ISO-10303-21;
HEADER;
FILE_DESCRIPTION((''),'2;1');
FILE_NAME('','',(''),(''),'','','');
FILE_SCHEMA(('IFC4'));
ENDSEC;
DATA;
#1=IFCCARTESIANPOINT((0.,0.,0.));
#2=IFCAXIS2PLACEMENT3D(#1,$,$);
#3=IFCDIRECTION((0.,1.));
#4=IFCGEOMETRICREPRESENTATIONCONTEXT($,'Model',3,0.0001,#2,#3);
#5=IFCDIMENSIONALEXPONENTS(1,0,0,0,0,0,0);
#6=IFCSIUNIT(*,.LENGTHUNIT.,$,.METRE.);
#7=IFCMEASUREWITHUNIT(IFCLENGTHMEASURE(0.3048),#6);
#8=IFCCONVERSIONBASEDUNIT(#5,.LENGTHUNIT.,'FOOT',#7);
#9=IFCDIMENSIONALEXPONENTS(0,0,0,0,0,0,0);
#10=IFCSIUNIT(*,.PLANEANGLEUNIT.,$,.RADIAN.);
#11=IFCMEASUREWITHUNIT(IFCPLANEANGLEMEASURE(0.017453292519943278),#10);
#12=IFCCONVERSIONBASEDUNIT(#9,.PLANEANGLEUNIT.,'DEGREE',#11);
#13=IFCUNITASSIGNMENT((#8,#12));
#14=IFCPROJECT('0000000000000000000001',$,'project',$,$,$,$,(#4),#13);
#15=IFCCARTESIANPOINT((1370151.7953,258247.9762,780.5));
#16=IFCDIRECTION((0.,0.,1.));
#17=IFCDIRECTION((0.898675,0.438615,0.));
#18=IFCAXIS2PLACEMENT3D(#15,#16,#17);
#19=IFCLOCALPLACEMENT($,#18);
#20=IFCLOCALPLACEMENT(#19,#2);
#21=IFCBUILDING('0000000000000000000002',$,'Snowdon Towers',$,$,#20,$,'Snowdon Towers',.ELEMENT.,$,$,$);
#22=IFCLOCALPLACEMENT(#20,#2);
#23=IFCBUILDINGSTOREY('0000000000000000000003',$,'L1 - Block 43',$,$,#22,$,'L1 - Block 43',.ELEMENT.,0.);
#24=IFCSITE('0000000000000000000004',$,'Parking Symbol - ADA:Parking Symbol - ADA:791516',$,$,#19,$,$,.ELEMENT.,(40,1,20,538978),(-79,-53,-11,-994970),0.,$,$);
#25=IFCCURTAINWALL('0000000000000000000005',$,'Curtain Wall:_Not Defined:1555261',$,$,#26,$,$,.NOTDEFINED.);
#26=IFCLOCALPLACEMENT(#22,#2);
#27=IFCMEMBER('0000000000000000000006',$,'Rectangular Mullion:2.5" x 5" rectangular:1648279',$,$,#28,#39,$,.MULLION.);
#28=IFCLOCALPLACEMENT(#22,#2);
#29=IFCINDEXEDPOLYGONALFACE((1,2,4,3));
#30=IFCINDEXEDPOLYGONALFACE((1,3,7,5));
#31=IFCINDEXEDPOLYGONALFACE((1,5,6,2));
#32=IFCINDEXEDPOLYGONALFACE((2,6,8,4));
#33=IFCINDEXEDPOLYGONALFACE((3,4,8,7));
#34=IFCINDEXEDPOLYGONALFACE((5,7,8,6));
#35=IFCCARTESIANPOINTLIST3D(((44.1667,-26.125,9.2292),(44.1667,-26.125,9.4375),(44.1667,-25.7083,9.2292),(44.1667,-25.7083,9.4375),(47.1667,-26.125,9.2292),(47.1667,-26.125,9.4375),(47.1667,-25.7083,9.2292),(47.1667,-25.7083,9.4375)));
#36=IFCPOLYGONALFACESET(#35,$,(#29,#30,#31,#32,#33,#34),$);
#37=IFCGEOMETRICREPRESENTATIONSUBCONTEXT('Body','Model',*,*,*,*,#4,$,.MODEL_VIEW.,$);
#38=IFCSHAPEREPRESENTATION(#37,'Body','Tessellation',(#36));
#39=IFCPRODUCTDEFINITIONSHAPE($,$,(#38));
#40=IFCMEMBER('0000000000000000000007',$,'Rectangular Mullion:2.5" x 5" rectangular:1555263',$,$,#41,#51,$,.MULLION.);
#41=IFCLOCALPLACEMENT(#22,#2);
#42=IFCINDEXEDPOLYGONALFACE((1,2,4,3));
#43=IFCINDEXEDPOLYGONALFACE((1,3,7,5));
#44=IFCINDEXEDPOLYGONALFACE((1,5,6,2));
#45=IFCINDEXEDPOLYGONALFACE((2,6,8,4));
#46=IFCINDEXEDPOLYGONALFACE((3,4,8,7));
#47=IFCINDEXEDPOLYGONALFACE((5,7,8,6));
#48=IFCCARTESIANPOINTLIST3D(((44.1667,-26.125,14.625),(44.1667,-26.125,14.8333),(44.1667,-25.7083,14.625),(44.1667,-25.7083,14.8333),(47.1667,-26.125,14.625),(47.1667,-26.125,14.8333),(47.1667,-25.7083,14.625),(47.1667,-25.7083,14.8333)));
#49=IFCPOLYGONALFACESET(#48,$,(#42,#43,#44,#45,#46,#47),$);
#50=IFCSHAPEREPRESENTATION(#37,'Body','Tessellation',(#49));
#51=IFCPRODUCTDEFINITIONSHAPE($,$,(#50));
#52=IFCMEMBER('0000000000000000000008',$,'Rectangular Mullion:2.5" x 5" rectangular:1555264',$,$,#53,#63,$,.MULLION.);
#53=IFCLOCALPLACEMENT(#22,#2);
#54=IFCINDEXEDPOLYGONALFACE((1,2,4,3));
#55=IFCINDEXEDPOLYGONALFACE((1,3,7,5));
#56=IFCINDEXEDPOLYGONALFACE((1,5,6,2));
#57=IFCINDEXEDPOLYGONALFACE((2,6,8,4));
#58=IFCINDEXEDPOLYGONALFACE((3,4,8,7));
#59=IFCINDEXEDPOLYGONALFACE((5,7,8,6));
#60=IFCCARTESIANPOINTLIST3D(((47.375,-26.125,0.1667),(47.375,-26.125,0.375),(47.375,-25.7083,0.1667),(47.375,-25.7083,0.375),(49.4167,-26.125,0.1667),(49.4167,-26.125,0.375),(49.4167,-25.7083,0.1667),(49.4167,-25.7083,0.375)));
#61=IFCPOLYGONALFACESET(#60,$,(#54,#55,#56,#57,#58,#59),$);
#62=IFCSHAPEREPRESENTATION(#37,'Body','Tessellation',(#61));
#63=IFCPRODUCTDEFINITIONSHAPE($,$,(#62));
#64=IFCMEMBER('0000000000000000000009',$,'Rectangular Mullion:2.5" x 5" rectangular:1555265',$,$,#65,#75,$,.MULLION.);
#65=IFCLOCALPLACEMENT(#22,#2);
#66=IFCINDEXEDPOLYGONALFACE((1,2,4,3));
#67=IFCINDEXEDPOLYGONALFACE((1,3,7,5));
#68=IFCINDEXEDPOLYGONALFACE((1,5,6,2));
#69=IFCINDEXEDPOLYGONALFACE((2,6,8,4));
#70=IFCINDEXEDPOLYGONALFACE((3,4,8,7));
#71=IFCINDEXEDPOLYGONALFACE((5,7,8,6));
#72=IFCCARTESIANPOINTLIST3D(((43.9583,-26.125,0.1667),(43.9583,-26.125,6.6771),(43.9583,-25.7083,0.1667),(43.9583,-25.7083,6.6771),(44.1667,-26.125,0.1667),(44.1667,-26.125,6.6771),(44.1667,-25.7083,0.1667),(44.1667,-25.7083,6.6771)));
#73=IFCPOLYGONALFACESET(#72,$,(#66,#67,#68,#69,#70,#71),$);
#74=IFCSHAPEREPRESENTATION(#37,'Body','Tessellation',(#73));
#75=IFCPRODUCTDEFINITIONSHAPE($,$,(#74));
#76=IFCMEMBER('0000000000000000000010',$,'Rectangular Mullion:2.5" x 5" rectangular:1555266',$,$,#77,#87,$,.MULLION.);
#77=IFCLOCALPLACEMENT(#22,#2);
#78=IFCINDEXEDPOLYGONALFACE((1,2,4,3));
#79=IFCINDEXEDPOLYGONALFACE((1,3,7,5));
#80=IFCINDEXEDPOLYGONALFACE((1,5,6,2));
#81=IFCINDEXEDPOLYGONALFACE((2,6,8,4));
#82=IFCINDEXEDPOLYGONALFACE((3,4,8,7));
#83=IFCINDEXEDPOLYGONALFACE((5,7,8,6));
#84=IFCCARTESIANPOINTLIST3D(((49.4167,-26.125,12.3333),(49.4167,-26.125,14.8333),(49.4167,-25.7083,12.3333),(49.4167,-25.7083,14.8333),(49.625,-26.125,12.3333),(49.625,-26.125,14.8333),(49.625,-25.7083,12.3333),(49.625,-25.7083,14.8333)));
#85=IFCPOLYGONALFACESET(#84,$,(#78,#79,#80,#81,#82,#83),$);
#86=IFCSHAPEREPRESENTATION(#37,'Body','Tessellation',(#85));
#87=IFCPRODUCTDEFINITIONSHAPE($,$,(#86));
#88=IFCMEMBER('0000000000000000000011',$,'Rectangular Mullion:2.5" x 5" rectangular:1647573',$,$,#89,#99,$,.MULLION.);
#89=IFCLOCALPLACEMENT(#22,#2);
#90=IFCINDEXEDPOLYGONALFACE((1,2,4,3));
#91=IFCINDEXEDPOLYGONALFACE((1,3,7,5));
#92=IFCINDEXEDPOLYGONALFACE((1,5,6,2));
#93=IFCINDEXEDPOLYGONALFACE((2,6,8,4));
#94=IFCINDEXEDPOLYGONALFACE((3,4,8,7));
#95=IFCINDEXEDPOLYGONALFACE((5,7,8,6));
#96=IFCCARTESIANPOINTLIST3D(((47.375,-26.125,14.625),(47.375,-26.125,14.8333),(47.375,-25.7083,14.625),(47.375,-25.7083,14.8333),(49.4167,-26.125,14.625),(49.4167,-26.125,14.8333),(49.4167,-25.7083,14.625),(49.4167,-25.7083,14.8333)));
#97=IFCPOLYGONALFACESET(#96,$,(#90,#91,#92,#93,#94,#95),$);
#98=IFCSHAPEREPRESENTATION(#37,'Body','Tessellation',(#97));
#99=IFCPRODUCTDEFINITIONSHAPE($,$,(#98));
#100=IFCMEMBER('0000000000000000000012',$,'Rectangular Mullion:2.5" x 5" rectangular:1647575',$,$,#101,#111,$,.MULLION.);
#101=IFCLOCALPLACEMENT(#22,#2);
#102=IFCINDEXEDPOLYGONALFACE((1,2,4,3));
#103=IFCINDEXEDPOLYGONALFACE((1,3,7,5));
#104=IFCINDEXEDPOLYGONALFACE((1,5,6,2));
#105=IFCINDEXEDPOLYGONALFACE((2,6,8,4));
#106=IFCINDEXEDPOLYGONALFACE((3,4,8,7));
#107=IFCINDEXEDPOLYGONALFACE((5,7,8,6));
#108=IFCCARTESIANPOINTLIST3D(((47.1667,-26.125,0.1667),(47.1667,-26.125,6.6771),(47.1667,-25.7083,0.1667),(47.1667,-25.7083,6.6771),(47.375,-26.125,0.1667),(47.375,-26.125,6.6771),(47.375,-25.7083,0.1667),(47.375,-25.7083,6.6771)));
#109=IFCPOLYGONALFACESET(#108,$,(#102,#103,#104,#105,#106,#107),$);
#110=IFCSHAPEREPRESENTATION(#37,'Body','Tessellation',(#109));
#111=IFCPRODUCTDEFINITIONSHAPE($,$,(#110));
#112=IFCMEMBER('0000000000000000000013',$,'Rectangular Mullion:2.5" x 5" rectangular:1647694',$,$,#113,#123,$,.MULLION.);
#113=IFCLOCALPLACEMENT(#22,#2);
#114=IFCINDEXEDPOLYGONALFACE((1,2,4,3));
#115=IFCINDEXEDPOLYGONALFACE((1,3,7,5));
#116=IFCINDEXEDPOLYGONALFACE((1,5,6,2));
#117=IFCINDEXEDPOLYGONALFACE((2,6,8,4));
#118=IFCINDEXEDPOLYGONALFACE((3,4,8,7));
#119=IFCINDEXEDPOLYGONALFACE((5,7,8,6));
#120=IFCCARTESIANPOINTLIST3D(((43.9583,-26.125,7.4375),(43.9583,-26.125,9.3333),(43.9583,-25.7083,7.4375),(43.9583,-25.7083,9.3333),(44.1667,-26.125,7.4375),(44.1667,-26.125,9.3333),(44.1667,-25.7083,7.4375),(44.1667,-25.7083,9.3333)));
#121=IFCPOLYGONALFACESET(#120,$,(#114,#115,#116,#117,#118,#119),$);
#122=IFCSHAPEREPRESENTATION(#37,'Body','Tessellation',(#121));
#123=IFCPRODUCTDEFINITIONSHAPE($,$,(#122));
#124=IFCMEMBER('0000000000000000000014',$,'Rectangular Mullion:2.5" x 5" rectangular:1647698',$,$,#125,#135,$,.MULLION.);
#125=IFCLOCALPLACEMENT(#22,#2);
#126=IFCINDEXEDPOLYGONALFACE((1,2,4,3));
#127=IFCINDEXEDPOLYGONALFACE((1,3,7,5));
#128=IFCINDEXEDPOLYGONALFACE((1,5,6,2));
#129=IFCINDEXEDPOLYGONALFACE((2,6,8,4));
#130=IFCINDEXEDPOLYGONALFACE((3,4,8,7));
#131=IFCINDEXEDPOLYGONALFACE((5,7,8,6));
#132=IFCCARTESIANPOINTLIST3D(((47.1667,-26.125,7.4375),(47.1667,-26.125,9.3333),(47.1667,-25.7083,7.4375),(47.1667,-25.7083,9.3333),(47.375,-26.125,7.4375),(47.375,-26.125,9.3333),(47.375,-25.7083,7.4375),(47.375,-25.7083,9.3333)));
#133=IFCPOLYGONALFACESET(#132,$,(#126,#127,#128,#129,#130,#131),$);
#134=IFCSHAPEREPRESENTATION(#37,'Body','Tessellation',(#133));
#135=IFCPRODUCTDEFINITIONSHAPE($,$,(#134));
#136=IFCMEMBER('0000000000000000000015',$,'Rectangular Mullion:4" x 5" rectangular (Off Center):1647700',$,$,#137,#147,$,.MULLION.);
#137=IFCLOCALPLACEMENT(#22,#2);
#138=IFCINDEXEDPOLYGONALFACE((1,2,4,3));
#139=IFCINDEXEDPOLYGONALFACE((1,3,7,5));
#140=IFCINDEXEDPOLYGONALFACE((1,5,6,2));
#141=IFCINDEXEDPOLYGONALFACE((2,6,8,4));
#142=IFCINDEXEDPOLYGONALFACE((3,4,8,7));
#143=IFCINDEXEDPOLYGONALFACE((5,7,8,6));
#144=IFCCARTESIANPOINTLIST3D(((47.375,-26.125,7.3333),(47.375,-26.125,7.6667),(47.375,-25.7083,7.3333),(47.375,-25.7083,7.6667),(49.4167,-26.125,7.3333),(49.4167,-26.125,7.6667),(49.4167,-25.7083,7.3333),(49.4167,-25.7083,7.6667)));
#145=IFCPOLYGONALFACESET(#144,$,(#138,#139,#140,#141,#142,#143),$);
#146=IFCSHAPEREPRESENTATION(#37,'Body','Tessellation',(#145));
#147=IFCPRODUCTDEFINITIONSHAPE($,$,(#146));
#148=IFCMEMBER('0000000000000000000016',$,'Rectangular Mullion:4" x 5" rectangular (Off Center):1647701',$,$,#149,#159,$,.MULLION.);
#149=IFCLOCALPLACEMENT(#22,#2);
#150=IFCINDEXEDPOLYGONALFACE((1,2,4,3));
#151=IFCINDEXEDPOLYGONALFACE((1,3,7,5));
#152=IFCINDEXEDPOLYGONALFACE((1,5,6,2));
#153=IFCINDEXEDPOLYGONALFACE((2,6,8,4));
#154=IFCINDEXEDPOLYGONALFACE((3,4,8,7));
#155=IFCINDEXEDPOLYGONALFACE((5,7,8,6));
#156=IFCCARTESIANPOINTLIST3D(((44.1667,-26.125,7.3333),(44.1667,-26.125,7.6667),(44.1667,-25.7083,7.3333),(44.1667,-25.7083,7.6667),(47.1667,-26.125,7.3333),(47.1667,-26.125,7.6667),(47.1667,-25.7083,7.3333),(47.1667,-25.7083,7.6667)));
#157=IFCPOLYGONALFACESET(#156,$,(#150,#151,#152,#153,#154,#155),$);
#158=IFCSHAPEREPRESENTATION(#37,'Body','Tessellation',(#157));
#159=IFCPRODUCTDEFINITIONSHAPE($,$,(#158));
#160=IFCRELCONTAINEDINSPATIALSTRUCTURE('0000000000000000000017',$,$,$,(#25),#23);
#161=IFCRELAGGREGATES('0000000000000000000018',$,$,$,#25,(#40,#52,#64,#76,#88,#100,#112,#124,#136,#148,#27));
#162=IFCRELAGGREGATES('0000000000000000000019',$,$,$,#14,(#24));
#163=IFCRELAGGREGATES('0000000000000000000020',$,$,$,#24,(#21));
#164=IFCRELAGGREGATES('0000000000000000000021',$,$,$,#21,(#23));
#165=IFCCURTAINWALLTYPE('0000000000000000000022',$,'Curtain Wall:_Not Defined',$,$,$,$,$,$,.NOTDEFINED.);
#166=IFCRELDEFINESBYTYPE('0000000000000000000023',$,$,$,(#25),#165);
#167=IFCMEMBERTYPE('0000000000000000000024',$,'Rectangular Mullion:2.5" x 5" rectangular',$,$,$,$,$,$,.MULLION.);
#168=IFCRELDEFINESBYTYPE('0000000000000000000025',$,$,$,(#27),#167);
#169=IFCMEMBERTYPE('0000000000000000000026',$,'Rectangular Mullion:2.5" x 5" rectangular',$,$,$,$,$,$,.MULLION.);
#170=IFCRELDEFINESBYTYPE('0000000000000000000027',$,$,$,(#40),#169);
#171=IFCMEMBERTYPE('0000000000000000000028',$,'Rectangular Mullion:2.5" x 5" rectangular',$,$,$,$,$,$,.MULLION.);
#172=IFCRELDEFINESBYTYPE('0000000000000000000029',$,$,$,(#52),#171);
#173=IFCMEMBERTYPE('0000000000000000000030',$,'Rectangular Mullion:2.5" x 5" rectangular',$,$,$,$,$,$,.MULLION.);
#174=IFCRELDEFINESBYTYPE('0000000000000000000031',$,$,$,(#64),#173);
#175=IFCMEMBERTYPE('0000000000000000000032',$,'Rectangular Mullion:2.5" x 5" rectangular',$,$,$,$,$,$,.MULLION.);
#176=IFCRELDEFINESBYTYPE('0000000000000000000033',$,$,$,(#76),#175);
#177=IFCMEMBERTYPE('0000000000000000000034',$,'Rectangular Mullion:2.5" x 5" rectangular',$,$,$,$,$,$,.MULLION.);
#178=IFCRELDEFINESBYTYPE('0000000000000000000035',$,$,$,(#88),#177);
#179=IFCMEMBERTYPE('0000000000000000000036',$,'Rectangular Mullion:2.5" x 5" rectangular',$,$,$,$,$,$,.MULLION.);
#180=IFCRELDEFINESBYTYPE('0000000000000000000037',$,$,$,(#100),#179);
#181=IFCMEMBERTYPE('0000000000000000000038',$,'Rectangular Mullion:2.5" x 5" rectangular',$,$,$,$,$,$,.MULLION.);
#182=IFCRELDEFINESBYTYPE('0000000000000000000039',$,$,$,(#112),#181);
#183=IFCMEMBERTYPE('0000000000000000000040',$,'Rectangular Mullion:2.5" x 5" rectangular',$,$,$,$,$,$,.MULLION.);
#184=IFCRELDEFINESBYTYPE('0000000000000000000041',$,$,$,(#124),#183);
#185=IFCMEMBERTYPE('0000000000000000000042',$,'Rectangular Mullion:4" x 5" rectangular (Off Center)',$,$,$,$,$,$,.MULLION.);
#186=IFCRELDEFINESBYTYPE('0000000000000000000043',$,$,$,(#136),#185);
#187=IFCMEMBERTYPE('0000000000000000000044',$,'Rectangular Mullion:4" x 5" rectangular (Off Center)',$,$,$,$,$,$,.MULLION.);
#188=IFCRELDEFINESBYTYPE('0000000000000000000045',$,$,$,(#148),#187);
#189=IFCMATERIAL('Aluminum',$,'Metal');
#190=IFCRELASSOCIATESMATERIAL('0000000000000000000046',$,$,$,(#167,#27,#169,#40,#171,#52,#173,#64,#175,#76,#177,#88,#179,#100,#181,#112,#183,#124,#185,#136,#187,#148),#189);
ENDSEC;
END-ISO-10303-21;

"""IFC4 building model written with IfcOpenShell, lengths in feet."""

from ifc_helpers import new_model, entity, si_unit, converted_unit, direction, frame, origin, place, context, subcontext, project, spatial, indexed_curve, outline, extrude, source, transform, mapped, material, type_object, type_shapes, element, aggregate, save


model = new_model("IFC4")

# Units and contexts
model_context = context("Model", 3, precision=0.0001, world=origin(), true_north=direction((0.0, 1.0)))
body_context = subcontext(model_context, "Body", "Model", "MODEL_VIEW")
ifc_project = project(units=[converted_unit("LENGTHUNIT", "FOOT", entity("IfcLengthMeasure", 0.3048), si_unit("LENGTHUNIT", "METRE"), dimensions=[1, 0, 0, 0, 0, 0, 0]), converted_unit("PLANEANGLEUNIT", "DEGREE", entity("IfcPlaneAngleMeasure", 0.017453292519943278), si_unit("PLANEANGLEUNIT", "RADIAN"), dimensions=[0, 0, 0, 0, 0, 0, 0])], contexts=[model_context])

# Site, building, storey
site_placement = place(None, frame((1370151.7953, 258247.9762, 780.5), z_axis=(0.0, 0.0, 1.0), x_axis=(0.898675, 0.438615, 0.0)))
site = spatial("IfcSite", under=ifc_project, at=site_placement, Name="Parking Symbol - ADA:Parking Symbol - ADA:791516", CompositionType="ELEMENT", RefLatitude=(40, 1, 20, 538978), RefLongitude=(-79, -53, -11, -994970), RefElevation=0.0)
building_placement = place(site_placement, origin())
building = spatial("IfcBuilding", under=site, at=building_placement, Name="Snowdon Towers", LongName="Snowdon Towers", CompositionType="ELEMENT")
storey_placement = place(building_placement, origin())
storey = spatial("IfcBuildingStorey", under=building, at=storey_placement, Name="L1 - Block 43", LongName="L1 - Block 43", CompositionType="ELEMENT", Elevation=0.0)

# Curtain wall, members
curtain_wall_type = type_object("IfcCurtainWallType", Name="Curtain Wall:_Not Defined", PredefinedType="NOTDEFINED")
curtain_wall_1_placement = place(storey_placement, origin())
curtain_wall_1 = element("IfcCurtainWall", 1, at=curtain_wall_1_placement, inside=storey, type_object=curtain_wall_type, Name="Curtain Wall:_Not Defined:1555261", PredefinedType="NOTDEFINED")
ifc_material_1 = material(Name="Aluminum", Category="Metal")
member_type_1 = type_object("IfcMemberType", Name="Rectangular Mullion:2.5\" x 5\" rectangular", PredefinedType="MULLION", material=ifc_material_1)
shared_shape_1 = source(origin(), body_context, "Body", "SweptSolid", [
    extrude(outline(indexed_curve([(-0.1042, -0.2083), (0.1042, -0.2083), (0.1042, 0.2083), (-0.1042, 0.2083), (-0.1042, -0.2083)], self_intersect=False)), frame((0.0, 0.0, -3.0), z_axis=(0.0, 0.0, 1.0), x_axis=(-1.0, 0.0, 0.0)), (0.0, 0.0, 1.0), 3.0),
])
type_shapes(member_type_1, [shared_shape_1])
member_1_placement = place(curtain_wall_1_placement, frame((44.1667, -25.9167, 9.3333), z_axis=(-1.0, 0.0, 0.0), x_axis=(0.0, 0.0, 1.0)))
member_1 = element("IfcMember", 2, at=member_1_placement, type_object=member_type_1, material=ifc_material_1, Name="Rectangular Mullion:2.5\" x 5\" rectangular:1648279", PredefinedType="MULLION", context=body_context, shape_type="MappedRepresentation", body=[
    mapped(shared_shape_1, transform((0.0, 0.0, 0.0), scale=1.0)),
])
member_type_2 = type_object("IfcMemberType", Name="Rectangular Mullion:2.5\" x 5\" rectangular", PredefinedType="MULLION", material=ifc_material_1)
shared_shape_2 = source(origin(), body_context, "Body", "SweptSolid", [
    extrude(outline(indexed_curve([(-0.1042, -0.2083), (0.1042, -0.2083), (0.1042, 0.2083), (-0.1042, 0.2083), (-0.1042, -0.2083)], self_intersect=False)), frame((-0.1042, 0.0, -3.0), z_axis=(0.0, 0.0, 1.0), x_axis=(-1.0, 0.0, 0.0)), (0.0, 0.0, 1.0), 3.0),
])
type_shapes(member_type_2, [shared_shape_2])
member_2_placement = place(curtain_wall_1_placement, frame((44.1667, -25.9167, 14.8333), z_axis=(-1.0, 0.0, 0.0), x_axis=(0.0, 0.0, 1.0)))
member_2 = element("IfcMember", 3, at=member_2_placement, type_object=member_type_2, material=ifc_material_1, Name="Rectangular Mullion:2.5\" x 5\" rectangular:1555263", PredefinedType="MULLION", context=body_context, shape_type="MappedRepresentation", body=[
    mapped(shared_shape_2, transform((0.0, 0.0, 0.0), scale=1.0)),
])
member_type_3 = type_object("IfcMemberType", Name="Rectangular Mullion:2.5\" x 5\" rectangular", PredefinedType="MULLION", material=ifc_material_1)
shared_shape_3 = source(origin(), body_context, "Body", "SweptSolid", [
    extrude(outline(indexed_curve([(-0.1042, -0.2083), (0.1042, -0.2083), (0.1042, 0.2083), (-0.1042, 0.2083), (-0.1042, -0.2083)], self_intersect=False)), frame((-0.1042, 0.0, -2.0417), z_axis=(0.0, 0.0, 1.0), x_axis=(-1.0, 0.0, 0.0)), (0.0, 0.0, 1.0), 2.0417),
])
type_shapes(member_type_3, [shared_shape_3])
member_3_placement = place(curtain_wall_1_placement, frame((49.4167, -25.9167, 0.1667), z_axis=(1.0, 0.0, 0.0), x_axis=(0.0, 0.0, -1.0)))
member_3 = element("IfcMember", 4, at=member_3_placement, type_object=member_type_3, material=ifc_material_1, Name="Rectangular Mullion:2.5\" x 5\" rectangular:1555264", PredefinedType="MULLION", context=body_context, shape_type="MappedRepresentation", body=[
    mapped(shared_shape_3, transform((0.0, 0.0, 0.0), scale=1.0)),
])
member_type_4 = type_object("IfcMemberType", Name="Rectangular Mullion:2.5\" x 5\" rectangular", PredefinedType="MULLION", material=ifc_material_1)
shared_shape_4 = source(origin(), body_context, "Body", "SweptSolid", [
    extrude(outline(indexed_curve([(-0.1042, -0.2083), (0.1042, -0.2083), (0.1042, 0.2083), (-0.1042, 0.2083), (-0.1042, -0.2083)], self_intersect=False)), frame((-0.1042, 0.0, -6.5104), z_axis=(0.0, 0.0, 1.0), x_axis=(-1.0, 0.0, 0.0)), (0.0, 0.0, 1.0), 6.5104),
])
type_shapes(member_type_4, [shared_shape_4])
member_4_placement = place(curtain_wall_1_placement, frame((43.9583, -25.9167, 0.1667), z_axis=(0.0, 0.0, -1.0), x_axis=(-1.0, 0.0, 0.0)))
member_4 = element("IfcMember", 5, at=member_4_placement, type_object=member_type_4, material=ifc_material_1, Name="Rectangular Mullion:2.5\" x 5\" rectangular:1555265", PredefinedType="MULLION", context=body_context, shape_type="MappedRepresentation", body=[
    mapped(shared_shape_4, transform((0.0, 0.0, 0.0), scale=1.0)),
])
member_type_5 = type_object("IfcMemberType", Name="Rectangular Mullion:2.5\" x 5\" rectangular", PredefinedType="MULLION", material=ifc_material_1)
shared_shape_5 = source(origin(), body_context, "Body", "SweptSolid", [
    extrude(outline(indexed_curve([(-0.1042, -0.2083), (0.1042, -0.2083), (0.1042, 0.2083), (-0.1042, 0.2083), (-0.1042, -0.2083)], self_intersect=False)), frame((-0.1042, 0.0, -2.5), z_axis=(0.0, 0.0, 1.0), x_axis=(-1.0, 0.0, 0.0)), (0.0, 0.0, 1.0), 2.5),
])
type_shapes(member_type_5, [shared_shape_5])
member_5_placement = place(curtain_wall_1_placement, frame((49.625, -25.9167, 14.8333)))
member_5 = element("IfcMember", 6, at=member_5_placement, type_object=member_type_5, material=ifc_material_1, Name="Rectangular Mullion:2.5\" x 5\" rectangular:1555266", PredefinedType="MULLION", context=body_context, shape_type="MappedRepresentation", body=[
    mapped(shared_shape_5, transform((0.0, 0.0, 0.0), scale=1.0)),
])
member_type_6 = type_object("IfcMemberType", Name="Rectangular Mullion:2.5\" x 5\" rectangular", PredefinedType="MULLION", material=ifc_material_1)
shared_shape_6 = source(origin(), body_context, "Body", "SweptSolid", [
    extrude(outline(indexed_curve([(-0.1042, -0.2083), (0.1042, -0.2083), (0.1042, 0.2083), (-0.1042, 0.2083), (-0.1042, -0.2083)], self_intersect=False)), frame((-0.1042, 0.0, -2.0417), z_axis=(0.0, 0.0, 1.0), x_axis=(-1.0, 0.0, 0.0)), (0.0, 0.0, 1.0), 2.0417),
])
type_shapes(member_type_6, [shared_shape_6])
member_6_placement = place(curtain_wall_1_placement, frame((47.375, -25.9167, 14.8333), z_axis=(-1.0, 0.0, 0.0), x_axis=(0.0, 0.0, 1.0)))
member_6 = element("IfcMember", 7, at=member_6_placement, type_object=member_type_6, material=ifc_material_1, Name="Rectangular Mullion:2.5\" x 5\" rectangular:1647573", PredefinedType="MULLION", context=body_context, shape_type="MappedRepresentation", body=[
    mapped(shared_shape_6, transform((0.0, 0.0, 0.0), scale=1.0)),
])
member_type_7 = type_object("IfcMemberType", Name="Rectangular Mullion:2.5\" x 5\" rectangular", PredefinedType="MULLION", material=ifc_material_1)
shared_shape_7 = source(origin(), body_context, "Body", "SweptSolid", [
    extrude(outline(indexed_curve([(-0.1042, -0.2083), (0.1042, -0.2083), (0.1042, 0.2083), (-0.1042, 0.2083), (-0.1042, -0.2083)], self_intersect=False)), frame((0.0, 0.0, -6.5104), z_axis=(0.0, 0.0, 1.0), x_axis=(-1.0, 0.0, 0.0)), (0.0, 0.0, 1.0), 6.5104),
])
type_shapes(member_type_7, [shared_shape_7])
member_7_placement = place(curtain_wall_1_placement, frame((47.2708, -25.9167, 0.1667), z_axis=(0.0, 0.0, -1.0), x_axis=(-1.0, 0.0, 0.0)))
member_7 = element("IfcMember", 8, at=member_7_placement, type_object=member_type_7, material=ifc_material_1, Name="Rectangular Mullion:2.5\" x 5\" rectangular:1647575", PredefinedType="MULLION", context=body_context, shape_type="MappedRepresentation", body=[
    mapped(shared_shape_7, transform((0.0, 0.0, 0.0), scale=1.0)),
])
member_type_8 = type_object("IfcMemberType", Name="Rectangular Mullion:2.5\" x 5\" rectangular", PredefinedType="MULLION", material=ifc_material_1)
shared_shape_8 = source(origin(), body_context, "Body", "SweptSolid", [
    extrude(outline(indexed_curve([(-0.1042, -0.2083), (0.1042, -0.2083), (0.1042, 0.2083), (-0.1042, 0.2083), (-0.1042, -0.2083)], self_intersect=False)), frame((-0.1042, 0.0, -1.8958), z_axis=(0.0, 0.0, 1.0), x_axis=(-1.0, 0.0, 0.0)), (0.0, 0.0, 1.0), 1.8958),
])
type_shapes(member_type_8, [shared_shape_8])
member_8_placement = place(curtain_wall_1_placement, frame((43.9583, -25.9167, 7.4375), z_axis=(0.0, 0.0, -1.0), x_axis=(-1.0, 0.0, 0.0)))
member_8 = element("IfcMember", 9, at=member_8_placement, type_object=member_type_8, material=ifc_material_1, Name="Rectangular Mullion:2.5\" x 5\" rectangular:1647694", PredefinedType="MULLION", context=body_context, shape_type="MappedRepresentation", body=[
    mapped(shared_shape_8, transform((0.0, 0.0, 0.0), scale=1.0)),
])
member_type_9 = type_object("IfcMemberType", Name="Rectangular Mullion:2.5\" x 5\" rectangular", PredefinedType="MULLION", material=ifc_material_1)
shared_shape_9 = source(origin(), body_context, "Body", "SweptSolid", [
    extrude(outline(indexed_curve([(-0.1042, -0.2083), (0.1042, -0.2083), (0.1042, 0.2083), (-0.1042, 0.2083), (-0.1042, -0.2083)], self_intersect=False)), frame((0.0, 0.0, -1.8958), z_axis=(0.0, 0.0, 1.0), x_axis=(-1.0, 0.0, 0.0)), (0.0, 0.0, 1.0), 1.8958),
])
type_shapes(member_type_9, [shared_shape_9])
member_9_placement = place(curtain_wall_1_placement, frame((47.2708, -25.9167, 7.4375), z_axis=(0.0, 0.0, -1.0), x_axis=(-1.0, 0.0, 0.0)))
member_9 = element("IfcMember", 10, at=member_9_placement, type_object=member_type_9, material=ifc_material_1, Name="Rectangular Mullion:2.5\" x 5\" rectangular:1647698", PredefinedType="MULLION", context=body_context, shape_type="MappedRepresentation", body=[
    mapped(shared_shape_9, transform((0.0, 0.0, 0.0), scale=1.0)),
])
member_type_10 = type_object("IfcMemberType", Name="Rectangular Mullion:4\" x 5\" rectangular (Off Center)", PredefinedType="MULLION", material=ifc_material_1)
shared_shape_10 = source(origin(), body_context, "Body", "SweptSolid", [
    extrude(outline(indexed_curve([(-0.1667, -0.2083), (0.1667, -0.2083), (0.1667, 0.2083), (-0.1667, 0.2083), (-0.1667, -0.2083)], self_intersect=False)), frame((0.0625, 0.0, -2.0417), z_axis=(0.0, 0.0, 1.0), x_axis=(-1.0, 0.0, 0.0)), (0.0, 0.0, 1.0), 2.0417),
])
type_shapes(member_type_10, [shared_shape_10])
member_10_placement = place(curtain_wall_1_placement, frame((47.375, -25.9167, 7.4375), z_axis=(-1.0, 0.0, 0.0), x_axis=(0.0, 0.0, 1.0)))
member_10 = element("IfcMember", 11, at=member_10_placement, type_object=member_type_10, material=ifc_material_1, Name="Rectangular Mullion:4\" x 5\" rectangular (Off Center):1647700", PredefinedType="MULLION", context=body_context, shape_type="MappedRepresentation", body=[
    mapped(shared_shape_10, transform((0.0, 0.0, 0.0), scale=1.0)),
])
member_type_11 = type_object("IfcMemberType", Name="Rectangular Mullion:4\" x 5\" rectangular (Off Center)", PredefinedType="MULLION", material=ifc_material_1)
shared_shape_11 = source(origin(), body_context, "Body", "SweptSolid", [
    extrude(outline(indexed_curve([(-0.1667, -0.2083), (0.1667, -0.2083), (0.1667, 0.2083), (-0.1667, 0.2083), (-0.1667, -0.2083)], self_intersect=False)), frame((0.0625, 0.0, -3.0), z_axis=(0.0, 0.0, 1.0), x_axis=(-1.0, 0.0, 0.0)), (0.0, 0.0, 1.0), 3.0),
])
type_shapes(member_type_11, [shared_shape_11])
member_11_placement = place(curtain_wall_1_placement, frame((44.1667, -25.9167, 7.4375), z_axis=(-1.0, 0.0, 0.0), x_axis=(0.0, 0.0, 1.0)))
member_11 = element("IfcMember", 12, at=member_11_placement, type_object=member_type_11, material=ifc_material_1, Name="Rectangular Mullion:4\" x 5\" rectangular (Off Center):1647701", PredefinedType="MULLION", context=body_context, shape_type="MappedRepresentation", body=[
    mapped(shared_shape_11, transform((0.0, 0.0, 0.0), scale=1.0)),
])

aggregate(curtain_wall_1, [member_2, member_3, member_4, member_5, member_6, member_7, member_8, member_9, member_10, member_11, member_1])

save(model, "model.ifc")
